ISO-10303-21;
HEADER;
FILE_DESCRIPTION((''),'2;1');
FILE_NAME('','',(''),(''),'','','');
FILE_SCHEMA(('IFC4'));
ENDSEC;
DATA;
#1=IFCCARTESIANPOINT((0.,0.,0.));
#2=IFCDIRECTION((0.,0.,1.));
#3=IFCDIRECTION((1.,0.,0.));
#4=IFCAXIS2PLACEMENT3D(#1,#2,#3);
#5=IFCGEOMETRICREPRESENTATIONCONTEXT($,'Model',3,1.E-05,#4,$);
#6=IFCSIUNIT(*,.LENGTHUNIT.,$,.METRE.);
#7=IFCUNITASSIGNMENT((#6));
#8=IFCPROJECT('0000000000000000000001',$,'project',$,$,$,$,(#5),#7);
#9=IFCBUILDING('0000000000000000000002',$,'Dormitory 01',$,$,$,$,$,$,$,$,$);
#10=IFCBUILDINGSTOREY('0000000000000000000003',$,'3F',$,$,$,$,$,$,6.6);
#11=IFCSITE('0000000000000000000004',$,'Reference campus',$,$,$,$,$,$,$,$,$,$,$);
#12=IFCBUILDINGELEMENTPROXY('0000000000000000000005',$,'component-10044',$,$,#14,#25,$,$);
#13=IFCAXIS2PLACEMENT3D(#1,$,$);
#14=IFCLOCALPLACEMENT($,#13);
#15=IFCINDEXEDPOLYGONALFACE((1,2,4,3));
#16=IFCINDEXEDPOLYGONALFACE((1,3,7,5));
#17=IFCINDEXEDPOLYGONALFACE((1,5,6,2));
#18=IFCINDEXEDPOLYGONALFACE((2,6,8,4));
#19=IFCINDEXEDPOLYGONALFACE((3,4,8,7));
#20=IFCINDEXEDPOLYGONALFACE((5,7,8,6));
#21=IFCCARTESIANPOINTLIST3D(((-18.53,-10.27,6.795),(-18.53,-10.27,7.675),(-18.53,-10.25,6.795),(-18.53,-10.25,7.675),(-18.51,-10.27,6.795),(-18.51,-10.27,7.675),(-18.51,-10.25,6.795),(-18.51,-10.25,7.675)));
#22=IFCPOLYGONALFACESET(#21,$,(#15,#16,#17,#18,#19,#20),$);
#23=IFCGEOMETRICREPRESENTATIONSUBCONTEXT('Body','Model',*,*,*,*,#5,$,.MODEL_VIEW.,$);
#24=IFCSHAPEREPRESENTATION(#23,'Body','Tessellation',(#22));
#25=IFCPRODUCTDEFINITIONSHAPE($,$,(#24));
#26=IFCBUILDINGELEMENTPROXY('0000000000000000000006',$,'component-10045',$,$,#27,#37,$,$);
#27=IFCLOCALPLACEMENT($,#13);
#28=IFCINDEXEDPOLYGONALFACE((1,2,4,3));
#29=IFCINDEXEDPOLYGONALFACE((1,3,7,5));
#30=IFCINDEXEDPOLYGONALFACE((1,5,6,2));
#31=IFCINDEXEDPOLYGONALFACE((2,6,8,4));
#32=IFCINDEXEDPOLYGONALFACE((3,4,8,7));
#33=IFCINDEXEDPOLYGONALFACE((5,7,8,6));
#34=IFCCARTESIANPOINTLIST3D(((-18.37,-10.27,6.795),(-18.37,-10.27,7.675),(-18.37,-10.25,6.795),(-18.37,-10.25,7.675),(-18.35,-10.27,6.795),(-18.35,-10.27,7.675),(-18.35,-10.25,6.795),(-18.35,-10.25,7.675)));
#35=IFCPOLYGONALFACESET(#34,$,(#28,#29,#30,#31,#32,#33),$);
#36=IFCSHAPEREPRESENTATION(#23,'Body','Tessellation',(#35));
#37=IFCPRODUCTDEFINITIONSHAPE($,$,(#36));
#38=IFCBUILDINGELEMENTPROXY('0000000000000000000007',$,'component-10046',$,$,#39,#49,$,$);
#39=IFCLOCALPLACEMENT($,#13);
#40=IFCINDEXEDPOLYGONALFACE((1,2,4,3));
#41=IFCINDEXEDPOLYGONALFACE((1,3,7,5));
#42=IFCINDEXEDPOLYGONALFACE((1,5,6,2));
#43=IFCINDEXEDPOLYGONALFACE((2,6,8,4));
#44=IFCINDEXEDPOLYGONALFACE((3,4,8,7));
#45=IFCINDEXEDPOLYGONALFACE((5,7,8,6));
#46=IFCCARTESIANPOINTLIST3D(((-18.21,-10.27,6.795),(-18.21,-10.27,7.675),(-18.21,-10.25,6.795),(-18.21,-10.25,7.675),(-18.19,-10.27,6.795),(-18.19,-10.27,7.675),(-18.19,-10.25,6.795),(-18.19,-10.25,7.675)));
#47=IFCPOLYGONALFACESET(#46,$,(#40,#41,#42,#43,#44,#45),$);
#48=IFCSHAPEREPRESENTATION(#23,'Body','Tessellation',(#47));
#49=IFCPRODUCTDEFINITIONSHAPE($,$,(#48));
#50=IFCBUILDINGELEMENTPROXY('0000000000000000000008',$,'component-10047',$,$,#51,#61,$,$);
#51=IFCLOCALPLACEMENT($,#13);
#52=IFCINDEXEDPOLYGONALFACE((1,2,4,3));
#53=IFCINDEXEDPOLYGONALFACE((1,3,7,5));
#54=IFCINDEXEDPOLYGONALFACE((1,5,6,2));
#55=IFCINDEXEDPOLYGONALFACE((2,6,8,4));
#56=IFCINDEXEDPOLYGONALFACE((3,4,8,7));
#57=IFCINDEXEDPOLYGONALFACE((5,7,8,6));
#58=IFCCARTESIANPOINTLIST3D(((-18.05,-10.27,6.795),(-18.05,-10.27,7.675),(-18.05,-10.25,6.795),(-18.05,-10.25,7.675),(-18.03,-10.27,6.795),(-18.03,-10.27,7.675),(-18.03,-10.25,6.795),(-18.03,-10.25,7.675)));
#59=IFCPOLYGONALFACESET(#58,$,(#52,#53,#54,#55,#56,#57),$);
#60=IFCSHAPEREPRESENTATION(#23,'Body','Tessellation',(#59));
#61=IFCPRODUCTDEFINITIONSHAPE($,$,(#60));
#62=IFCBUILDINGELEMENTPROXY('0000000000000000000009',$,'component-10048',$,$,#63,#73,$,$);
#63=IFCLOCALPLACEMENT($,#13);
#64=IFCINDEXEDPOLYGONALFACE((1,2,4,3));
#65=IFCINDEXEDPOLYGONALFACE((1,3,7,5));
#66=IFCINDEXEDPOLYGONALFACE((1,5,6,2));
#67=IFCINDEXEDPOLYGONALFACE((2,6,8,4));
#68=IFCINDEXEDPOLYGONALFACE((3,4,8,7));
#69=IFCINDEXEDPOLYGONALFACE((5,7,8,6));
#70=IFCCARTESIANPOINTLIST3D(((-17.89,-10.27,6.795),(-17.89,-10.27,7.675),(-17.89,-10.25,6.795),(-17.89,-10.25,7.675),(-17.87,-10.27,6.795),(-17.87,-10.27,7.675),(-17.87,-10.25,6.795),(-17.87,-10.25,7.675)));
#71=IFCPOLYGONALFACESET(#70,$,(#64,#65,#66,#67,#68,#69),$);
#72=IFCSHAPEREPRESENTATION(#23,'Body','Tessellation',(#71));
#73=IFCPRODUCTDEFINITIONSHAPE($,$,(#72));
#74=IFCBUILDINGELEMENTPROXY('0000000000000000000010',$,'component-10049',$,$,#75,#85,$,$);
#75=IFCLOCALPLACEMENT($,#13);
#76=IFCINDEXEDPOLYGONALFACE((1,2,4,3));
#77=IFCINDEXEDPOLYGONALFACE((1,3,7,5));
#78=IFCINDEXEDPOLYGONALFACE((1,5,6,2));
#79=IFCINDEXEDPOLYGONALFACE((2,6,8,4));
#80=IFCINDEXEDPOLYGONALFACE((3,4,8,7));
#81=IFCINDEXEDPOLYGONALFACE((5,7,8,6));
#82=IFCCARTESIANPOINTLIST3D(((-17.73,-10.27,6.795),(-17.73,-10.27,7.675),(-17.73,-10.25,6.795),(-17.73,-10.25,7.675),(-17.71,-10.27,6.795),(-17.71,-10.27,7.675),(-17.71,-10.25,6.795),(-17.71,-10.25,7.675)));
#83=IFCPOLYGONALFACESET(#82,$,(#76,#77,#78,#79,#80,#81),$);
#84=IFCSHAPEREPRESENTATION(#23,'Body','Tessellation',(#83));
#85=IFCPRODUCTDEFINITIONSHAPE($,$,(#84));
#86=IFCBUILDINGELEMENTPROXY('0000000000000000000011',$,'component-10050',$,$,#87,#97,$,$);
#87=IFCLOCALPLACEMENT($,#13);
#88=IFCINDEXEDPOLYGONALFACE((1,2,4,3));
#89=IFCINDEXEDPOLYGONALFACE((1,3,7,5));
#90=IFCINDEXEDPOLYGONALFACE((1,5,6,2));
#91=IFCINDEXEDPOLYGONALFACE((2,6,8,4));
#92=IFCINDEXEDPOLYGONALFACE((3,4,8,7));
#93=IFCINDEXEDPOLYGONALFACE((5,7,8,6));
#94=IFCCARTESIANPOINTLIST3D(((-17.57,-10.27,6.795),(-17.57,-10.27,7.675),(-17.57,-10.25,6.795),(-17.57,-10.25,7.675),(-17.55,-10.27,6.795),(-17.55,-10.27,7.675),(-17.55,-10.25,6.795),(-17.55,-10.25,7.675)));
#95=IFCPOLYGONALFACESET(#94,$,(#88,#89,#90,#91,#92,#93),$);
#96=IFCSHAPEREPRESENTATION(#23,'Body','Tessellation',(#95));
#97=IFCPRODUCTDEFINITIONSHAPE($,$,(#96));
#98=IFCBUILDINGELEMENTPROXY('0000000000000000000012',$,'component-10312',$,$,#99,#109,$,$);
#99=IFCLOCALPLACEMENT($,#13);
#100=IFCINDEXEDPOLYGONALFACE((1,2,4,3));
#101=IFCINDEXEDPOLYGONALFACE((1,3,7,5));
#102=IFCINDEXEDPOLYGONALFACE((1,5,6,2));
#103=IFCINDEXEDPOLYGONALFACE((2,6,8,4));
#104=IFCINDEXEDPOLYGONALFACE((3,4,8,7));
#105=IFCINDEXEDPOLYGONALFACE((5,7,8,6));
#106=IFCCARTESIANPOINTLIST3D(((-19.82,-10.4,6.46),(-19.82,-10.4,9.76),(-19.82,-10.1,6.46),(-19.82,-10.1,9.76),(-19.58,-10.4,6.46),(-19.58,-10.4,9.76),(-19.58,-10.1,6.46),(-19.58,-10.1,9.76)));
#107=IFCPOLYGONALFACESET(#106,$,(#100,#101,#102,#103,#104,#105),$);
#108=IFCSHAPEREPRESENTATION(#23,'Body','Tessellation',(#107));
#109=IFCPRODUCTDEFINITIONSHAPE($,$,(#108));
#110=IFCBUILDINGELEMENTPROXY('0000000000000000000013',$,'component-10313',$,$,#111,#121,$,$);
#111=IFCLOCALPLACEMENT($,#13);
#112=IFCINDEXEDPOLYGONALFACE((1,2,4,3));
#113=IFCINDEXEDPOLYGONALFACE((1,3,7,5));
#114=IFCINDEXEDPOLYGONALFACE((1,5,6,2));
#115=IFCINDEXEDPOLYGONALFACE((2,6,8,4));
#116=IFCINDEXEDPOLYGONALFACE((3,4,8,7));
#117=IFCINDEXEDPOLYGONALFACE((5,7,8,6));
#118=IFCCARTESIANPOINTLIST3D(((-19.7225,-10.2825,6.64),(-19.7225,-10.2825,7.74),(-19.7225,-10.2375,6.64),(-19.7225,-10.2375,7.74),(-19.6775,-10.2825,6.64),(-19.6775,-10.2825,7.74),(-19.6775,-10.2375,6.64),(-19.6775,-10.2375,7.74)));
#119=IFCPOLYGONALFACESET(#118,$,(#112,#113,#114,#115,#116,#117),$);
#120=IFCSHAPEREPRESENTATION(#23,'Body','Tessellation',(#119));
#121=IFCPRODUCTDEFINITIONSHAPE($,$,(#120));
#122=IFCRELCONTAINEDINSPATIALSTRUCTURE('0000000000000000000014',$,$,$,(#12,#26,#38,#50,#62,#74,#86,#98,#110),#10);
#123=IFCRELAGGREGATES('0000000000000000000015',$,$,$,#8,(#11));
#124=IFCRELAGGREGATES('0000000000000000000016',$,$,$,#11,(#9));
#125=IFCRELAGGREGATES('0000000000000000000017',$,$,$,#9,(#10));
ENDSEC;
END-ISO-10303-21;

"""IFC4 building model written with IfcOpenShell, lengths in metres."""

from ifc_helpers import new_model, si_unit, frame, origin, origin_with_axes, origin_2d, place, context, subcontext, project, spatial, rectangle, extrude, element, save


model = new_model("IFC4")

# Units and contexts
model_context = context("Model", 3, precision=1e-05, world=origin_with_axes())
body_context = subcontext(model_context, "Body", "Model", "MODEL_VIEW")
ifc_project = project(units=[si_unit("LENGTHUNIT", "METRE")], contexts=[model_context])

# Site, building, storey
site = spatial("IfcSite", under=ifc_project, Name="Reference campus")
building = spatial("IfcBuilding", under=site, Name="Dormitory 01")
storey = spatial("IfcBuildingStorey", under=building, Name="3F", Elevation=6.6)

# Building element proxies
for number, where, z_axis, x_axis, name in (
    (1, (-18.52, -10.26, 6.795), (0.0, 0.0, 1.0), (1.0, 0.0, 0.0), "component-10044"),
    (2, (-18.36, -10.26, 6.795), (0.0, 0.0, 1.0), (1.0, 0.0, 0.0), "component-10045"),
    (3, (-18.2, -10.26, 6.795), (0.0, 0.0, 1.0), (1.0, 0.0, 0.0), "component-10046"),
    (4, (-18.04, -10.26, 6.795), (0.0, 0.0, 1.0), (1.0, 0.0, 0.0), "component-10047"),
    (5, (-17.88, -10.26, 6.795), (0.0, 0.0, 1.0), (1.0, 0.0, 0.0), "component-10048"),
    (6, (-17.72, -10.26, 6.795), (0.0, 0.0, 1.0), (1.0, 0.0, 0.0), "component-10049"),
    (7, (-17.56, -10.26, 6.795), (0.0, 0.0, 1.0), (1.0, 0.0, 0.0), "component-10050"),
):
    element("IfcBuildingElementProxy", number, at=place(None, frame(where, z_axis=z_axis, x_axis=x_axis)), inside=storey, Name=name, context=body_context, shape_type="SweptSolid", body=[
        extrude(rectangle(XDim=0.02, YDim=0.02, at=origin_2d()), origin(), (0.0, 0.0, 1.0), 0.88),
    ])
proxy_1_placement = place(None, frame((-19.7, -10.25, 6.46), z_axis=(0.0, 0.0, 1.0), x_axis=(1.0, 0.0, 0.0)))
element("IfcBuildingElementProxy", 8, at=proxy_1_placement, inside=storey, Name="component-10312", context=body_context, shape_type="SweptSolid", body=[
    extrude(rectangle(XDim=0.24, YDim=0.3, at=origin_2d()), origin(), (0.0, 0.0, 1.0), 3.3),
])
proxy_2_placement = place(None, frame((-19.7, -10.26, 6.64), z_axis=(0.0, 0.0, 1.0), x_axis=(1.0, 0.0, 0.0)))
element("IfcBuildingElementProxy", 9, at=proxy_2_placement, inside=storey, Name="component-10313", context=body_context, shape_type="SweptSolid", body=[
    extrude(rectangle(XDim=0.045, YDim=0.045, at=origin_2d()), origin(), (0.0, 0.0, 1.0), 1.1),
])

save(model, "model.ifc")
